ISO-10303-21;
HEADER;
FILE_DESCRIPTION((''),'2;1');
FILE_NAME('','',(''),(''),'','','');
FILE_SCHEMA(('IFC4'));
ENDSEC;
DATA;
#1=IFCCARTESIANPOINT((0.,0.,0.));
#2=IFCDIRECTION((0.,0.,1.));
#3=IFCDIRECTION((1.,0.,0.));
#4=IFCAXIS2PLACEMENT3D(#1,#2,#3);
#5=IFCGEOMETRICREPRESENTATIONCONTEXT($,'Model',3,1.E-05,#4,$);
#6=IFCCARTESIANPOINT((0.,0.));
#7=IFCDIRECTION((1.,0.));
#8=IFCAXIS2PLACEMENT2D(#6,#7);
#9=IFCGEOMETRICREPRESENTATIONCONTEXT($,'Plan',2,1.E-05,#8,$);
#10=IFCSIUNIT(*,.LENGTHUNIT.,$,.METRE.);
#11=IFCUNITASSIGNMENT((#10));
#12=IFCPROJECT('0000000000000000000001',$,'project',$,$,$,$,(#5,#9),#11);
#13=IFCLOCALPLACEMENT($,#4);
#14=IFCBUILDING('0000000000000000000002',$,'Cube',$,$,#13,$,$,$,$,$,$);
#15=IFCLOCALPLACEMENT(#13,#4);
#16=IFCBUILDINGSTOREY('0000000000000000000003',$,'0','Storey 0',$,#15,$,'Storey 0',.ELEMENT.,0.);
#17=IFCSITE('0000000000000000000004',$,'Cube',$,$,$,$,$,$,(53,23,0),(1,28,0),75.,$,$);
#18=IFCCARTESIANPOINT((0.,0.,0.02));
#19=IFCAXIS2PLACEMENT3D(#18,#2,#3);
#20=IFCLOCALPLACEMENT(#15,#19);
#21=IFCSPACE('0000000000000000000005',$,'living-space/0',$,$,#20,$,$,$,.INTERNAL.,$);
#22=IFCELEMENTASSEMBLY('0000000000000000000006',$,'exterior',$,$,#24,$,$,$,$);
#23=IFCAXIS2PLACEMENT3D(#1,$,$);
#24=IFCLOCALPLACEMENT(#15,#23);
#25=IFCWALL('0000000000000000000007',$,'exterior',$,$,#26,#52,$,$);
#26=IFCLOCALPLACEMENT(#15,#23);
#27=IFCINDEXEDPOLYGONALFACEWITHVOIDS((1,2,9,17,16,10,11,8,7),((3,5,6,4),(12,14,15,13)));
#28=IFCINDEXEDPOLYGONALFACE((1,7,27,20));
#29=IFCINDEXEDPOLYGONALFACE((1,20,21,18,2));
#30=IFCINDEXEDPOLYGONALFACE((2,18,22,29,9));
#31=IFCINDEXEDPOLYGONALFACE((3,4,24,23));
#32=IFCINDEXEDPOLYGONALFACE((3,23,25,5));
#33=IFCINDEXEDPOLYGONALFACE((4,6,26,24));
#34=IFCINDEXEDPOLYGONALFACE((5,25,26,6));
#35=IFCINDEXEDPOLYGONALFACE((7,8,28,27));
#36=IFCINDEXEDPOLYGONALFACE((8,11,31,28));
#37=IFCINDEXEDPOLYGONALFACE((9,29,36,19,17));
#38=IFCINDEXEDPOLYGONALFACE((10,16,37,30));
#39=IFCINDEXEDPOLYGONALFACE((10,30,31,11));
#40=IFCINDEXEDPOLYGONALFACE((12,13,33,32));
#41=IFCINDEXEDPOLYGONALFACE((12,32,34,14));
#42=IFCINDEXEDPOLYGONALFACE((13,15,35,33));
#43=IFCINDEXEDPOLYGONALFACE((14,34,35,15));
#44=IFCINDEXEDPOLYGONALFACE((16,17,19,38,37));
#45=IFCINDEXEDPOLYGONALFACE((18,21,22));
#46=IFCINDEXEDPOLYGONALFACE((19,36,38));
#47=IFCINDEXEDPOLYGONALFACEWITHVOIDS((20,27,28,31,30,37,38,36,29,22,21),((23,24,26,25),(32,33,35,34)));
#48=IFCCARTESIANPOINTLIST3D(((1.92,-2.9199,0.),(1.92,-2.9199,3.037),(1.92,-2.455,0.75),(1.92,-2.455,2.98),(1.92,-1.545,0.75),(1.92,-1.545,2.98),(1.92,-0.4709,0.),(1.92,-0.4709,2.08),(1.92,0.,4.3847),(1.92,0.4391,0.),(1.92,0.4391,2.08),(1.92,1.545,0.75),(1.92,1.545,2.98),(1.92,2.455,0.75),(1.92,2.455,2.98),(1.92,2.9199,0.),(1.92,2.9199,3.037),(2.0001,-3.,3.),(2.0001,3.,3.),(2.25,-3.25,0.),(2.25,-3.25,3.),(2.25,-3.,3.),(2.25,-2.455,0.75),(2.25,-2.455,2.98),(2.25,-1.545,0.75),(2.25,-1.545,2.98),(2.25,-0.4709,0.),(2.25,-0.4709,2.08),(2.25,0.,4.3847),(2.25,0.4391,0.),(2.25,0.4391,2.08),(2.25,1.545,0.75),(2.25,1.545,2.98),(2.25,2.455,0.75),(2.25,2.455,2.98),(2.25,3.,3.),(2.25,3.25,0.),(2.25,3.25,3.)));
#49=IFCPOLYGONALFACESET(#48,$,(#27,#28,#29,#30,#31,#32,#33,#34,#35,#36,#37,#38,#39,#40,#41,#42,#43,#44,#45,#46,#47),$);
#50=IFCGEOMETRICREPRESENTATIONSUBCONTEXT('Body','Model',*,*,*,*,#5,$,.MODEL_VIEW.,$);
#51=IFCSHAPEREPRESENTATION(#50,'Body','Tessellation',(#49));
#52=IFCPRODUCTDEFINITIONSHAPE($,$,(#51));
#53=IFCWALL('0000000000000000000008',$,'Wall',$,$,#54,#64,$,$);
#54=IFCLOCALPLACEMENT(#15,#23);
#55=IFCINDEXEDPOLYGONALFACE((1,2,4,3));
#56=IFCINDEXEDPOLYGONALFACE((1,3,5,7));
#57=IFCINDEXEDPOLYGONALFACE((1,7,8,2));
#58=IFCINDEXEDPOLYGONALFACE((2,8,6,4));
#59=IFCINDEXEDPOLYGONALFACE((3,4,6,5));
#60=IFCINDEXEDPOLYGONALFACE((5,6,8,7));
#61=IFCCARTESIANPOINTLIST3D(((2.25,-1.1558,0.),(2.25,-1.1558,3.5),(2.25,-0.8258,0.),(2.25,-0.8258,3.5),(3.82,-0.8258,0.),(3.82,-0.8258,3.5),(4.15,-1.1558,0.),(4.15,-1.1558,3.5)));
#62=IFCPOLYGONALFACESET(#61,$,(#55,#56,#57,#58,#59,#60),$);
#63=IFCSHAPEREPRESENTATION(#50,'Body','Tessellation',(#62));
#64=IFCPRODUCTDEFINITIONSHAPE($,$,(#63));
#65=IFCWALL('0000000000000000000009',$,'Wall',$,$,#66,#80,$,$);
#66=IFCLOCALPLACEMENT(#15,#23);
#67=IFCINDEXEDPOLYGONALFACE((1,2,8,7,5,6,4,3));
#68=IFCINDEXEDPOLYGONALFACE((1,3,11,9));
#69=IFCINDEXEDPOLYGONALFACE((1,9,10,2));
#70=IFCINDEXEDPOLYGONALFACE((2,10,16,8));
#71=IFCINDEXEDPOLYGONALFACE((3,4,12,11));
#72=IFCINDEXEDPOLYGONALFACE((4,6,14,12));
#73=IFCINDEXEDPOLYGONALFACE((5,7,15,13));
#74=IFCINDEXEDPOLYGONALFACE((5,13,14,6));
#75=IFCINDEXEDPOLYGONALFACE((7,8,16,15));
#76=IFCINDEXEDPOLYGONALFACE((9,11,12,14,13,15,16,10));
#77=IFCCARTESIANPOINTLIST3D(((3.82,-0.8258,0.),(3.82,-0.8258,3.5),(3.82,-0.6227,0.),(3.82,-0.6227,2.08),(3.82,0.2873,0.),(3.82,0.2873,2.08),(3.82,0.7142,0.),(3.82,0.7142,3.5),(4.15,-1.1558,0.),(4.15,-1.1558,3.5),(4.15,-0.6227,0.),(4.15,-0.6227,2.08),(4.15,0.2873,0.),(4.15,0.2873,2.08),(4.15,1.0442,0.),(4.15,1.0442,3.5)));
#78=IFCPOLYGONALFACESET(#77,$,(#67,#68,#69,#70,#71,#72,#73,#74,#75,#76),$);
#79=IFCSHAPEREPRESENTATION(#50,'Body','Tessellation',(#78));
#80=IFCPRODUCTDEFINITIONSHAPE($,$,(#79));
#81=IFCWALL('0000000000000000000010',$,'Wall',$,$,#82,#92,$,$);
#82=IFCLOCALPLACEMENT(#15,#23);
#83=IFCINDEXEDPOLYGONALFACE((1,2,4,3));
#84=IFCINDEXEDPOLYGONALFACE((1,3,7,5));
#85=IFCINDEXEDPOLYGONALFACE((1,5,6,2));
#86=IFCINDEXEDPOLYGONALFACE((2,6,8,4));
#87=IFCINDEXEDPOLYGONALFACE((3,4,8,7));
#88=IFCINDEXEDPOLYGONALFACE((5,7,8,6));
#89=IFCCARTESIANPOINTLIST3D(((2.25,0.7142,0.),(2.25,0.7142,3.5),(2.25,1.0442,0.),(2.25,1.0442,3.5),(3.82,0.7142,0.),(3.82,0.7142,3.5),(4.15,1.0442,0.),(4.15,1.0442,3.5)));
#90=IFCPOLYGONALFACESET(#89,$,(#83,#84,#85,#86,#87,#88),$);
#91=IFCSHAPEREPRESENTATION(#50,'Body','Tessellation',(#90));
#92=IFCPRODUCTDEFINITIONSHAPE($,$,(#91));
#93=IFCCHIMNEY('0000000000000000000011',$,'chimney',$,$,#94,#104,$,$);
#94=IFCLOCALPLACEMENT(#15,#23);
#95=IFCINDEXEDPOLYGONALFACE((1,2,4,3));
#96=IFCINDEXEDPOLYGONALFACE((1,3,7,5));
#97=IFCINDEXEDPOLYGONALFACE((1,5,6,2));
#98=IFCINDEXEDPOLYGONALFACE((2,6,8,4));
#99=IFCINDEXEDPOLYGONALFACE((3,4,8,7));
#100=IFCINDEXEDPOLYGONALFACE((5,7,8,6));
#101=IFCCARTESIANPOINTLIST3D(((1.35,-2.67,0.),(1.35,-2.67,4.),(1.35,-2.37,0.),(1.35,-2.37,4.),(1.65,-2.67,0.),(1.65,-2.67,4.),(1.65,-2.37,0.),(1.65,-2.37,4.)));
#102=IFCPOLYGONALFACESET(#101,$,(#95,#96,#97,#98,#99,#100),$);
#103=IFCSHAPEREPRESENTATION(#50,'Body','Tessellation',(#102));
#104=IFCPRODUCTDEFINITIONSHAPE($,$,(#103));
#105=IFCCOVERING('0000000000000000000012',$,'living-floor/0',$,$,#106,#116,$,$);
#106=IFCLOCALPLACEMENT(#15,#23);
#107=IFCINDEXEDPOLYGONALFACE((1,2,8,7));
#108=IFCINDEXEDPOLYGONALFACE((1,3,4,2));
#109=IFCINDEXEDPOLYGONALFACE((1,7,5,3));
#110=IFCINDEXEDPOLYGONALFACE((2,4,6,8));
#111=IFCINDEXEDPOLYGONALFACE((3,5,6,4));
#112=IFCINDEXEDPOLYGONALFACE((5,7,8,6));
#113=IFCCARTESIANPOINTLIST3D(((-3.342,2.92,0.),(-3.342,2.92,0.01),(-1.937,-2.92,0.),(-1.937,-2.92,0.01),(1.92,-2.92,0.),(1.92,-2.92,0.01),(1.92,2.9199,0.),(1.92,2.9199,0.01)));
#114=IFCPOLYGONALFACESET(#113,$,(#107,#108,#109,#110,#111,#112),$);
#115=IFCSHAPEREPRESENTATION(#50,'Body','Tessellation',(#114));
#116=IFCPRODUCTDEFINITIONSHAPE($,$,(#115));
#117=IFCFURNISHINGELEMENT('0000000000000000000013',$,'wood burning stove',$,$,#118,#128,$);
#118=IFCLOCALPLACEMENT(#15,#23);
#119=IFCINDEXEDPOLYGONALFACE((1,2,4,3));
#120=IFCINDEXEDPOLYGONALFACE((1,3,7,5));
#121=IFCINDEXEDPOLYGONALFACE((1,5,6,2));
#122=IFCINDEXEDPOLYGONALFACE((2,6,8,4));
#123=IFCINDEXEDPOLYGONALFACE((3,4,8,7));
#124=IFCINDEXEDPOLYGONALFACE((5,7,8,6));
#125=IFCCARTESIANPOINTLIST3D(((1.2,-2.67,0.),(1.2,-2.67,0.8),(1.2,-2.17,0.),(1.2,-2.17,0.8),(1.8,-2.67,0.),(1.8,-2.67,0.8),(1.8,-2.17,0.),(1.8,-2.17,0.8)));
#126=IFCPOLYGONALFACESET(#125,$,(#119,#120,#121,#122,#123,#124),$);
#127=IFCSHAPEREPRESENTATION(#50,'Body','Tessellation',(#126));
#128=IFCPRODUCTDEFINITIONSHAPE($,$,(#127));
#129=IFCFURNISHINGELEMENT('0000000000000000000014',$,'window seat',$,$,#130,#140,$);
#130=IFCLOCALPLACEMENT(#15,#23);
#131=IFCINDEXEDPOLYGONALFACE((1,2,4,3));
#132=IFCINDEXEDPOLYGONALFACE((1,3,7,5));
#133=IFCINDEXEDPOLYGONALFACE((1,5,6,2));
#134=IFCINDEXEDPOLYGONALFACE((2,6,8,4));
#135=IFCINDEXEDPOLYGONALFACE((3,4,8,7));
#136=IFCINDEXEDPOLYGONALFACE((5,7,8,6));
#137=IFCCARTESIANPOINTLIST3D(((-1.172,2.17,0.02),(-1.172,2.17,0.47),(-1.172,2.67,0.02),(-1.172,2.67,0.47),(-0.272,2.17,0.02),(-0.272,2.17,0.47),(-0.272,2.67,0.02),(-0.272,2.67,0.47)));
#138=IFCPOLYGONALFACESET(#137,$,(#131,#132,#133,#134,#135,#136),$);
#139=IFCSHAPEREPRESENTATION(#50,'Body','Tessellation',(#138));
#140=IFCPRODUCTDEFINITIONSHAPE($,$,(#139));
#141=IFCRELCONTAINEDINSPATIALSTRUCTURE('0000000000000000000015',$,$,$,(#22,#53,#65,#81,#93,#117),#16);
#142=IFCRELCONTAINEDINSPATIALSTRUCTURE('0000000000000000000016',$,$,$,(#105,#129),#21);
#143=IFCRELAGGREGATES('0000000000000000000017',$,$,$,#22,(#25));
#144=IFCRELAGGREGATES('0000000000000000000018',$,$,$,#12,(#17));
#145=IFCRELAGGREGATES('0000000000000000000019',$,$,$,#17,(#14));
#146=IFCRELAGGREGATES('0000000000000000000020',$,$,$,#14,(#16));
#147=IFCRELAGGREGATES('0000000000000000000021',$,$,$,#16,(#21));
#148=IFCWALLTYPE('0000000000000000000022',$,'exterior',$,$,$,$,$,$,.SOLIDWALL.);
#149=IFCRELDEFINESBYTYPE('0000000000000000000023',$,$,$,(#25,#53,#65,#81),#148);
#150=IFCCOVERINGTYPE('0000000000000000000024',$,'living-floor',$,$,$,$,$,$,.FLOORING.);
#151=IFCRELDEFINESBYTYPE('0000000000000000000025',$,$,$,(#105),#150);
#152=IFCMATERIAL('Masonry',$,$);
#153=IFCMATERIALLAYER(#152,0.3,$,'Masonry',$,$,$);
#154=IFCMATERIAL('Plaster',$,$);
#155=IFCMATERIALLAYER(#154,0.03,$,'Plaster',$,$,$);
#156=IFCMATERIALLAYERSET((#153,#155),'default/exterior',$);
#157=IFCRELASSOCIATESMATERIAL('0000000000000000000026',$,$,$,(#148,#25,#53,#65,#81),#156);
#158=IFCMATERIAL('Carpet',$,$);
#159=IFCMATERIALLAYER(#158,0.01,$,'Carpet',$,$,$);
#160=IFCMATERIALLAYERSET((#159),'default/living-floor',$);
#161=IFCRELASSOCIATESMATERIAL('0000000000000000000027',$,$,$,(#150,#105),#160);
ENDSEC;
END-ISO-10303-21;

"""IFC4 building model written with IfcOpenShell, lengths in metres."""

from ifc_helpers import new_model, si_unit, frame, origin, origin_with_axes, origin_2d_with_axis, place, context, subcontext, project, spatial, polyline, line, indexed_curve, outline, extrude, clip, bounded_halfspace, source, transform, mapped, material, layer, layer_set, layer_usage, type_object, element, aggregate, save


model = new_model("IFC4")

# Units and contexts
model_context = context("Model", 3, precision=1e-05, world=origin_with_axes())
plan_context = context("Plan", 2, precision=1e-05, world=origin_2d_with_axis())
body_context = subcontext(model_context, "Body", "Model", "MODEL_VIEW")
ifc_project = project(units=[si_unit("LENGTHUNIT", "METRE")], contexts=[model_context, plan_context])

# Site, building, storey
site = spatial("IfcSite", under=ifc_project, Name="Cube", RefLatitude=(53, 23, 0), RefLongitude=(1, 28, 0), RefElevation=75.0)
building_placement = place(None, origin_with_axes())
building = spatial("IfcBuilding", under=site, at=building_placement, Name="Cube")
storey_placement = place(building_placement, origin_with_axes())
storey = spatial("IfcBuildingStorey", under=building, at=storey_placement, Name="0", Description="Storey 0", LongName="Storey 0", CompositionType="ELEMENT", Elevation=0.0)

# Element assembly, wall, openings
ifc_material_1 = material(Name="Masonry")
ifc_layer_1 = layer(ifc_material_1, 0.3, Name="Masonry")
ifc_material_2 = material(Name="Plaster")
ifc_layer_2 = layer(ifc_material_2, 0.03, Name="Plaster")
ifc_layer_set_1 = layer_set([ifc_layer_1, ifc_layer_2], Name="default/exterior")
wall_type = type_object("IfcWallType", Name="exterior", PredefinedType="SOLIDWALL", material=ifc_layer_set_1)
assembly_1_placement = place(storey_placement, frame((2.0, -3.0, 0.0), z_axis=(0.0, 0.0, 1.0), x_axis=(0.0, 1.0, 0.0)))
assembly_1 = element("IfcElementAssembly", 1, at=assembly_1_placement, inside=storey, Name="exterior")
ifc_layer_usage_1 = layer_usage(ifc_layer_set_1, "AXIS2", "POSITIVE", -0.25)
wall_1_placement = place(assembly_1_placement, origin_with_axes())
wall_1 = element("IfcWall", 2, at=wall_1_placement, type_object=wall_type, material=ifc_layer_usage_1, Name="exterior", context=body_context, shape_type="Clipping", body=[
    clip(clip(clip(clip(extrude(outline(polyline([(0.0801, 0.08), (-0.25, -0.25), (6.25, -0.25), (5.9199, 0.08), (0.0801, 0.08)])), origin(), (0.0, 0.0, 1.0), 4.385), bounded_halfspace(frame((6.0, 0.0, 3.0), z_axis=(0.419069, 0.0, 0.907954), x_axis=(0.0, -1.0, 0.0)), False, origin(), polyline([(6.0, -1.0), (3.0, -1.0), (3.0, 1.0), (6.0, 1.0), (6.0, -1.0)]))), bounded_halfspace(frame((6.0, 0.0, 3.0), z_axis=(0.0, 0.0, 1.0), x_axis=(0.0, 1.0, 0.0)), False, origin(), polyline([(6.0, 1.0), (7.0, 1.0), (7.0, -1.0), (6.0, -1.0), (6.0, 1.0)]))), bounded_halfspace(frame((3.0, 0.0, 4.3847), z_axis=(-0.419069, 0.0, 0.907954), x_axis=(0.0, -1.0, 0.0)), False, origin(), polyline([(3.0, -1.0), (0.0, -1.0), (0.0, 1.0), (3.0, 1.0), (3.0, -1.0)]))), bounded_halfspace(frame((0.0, 0.0, 3.0), z_axis=(0.0, 0.0, 1.0), x_axis=(0.0, -1.0, 0.0)), False, origin(), polyline([(0.0, -1.0), (-1.0, -1.0), (-1.0, 1.0), (0.0, 1.0), (0.0, -1.0)]))),
])
opening_1_placement = place(wall_1_placement, frame((0.545, -0.25, 0.75), z_axis=(0.0, 0.0, 1.0), x_axis=(1.0, 0.0, 0.0)))
element("IfcOpeningElement", 3, at=opening_1_placement, cuts=wall_1, PredefinedType="OPENING", context=body_context, shape_type="SweptSolid", body=[
    extrude(outline(polyline([(0.0, -0.02), (0.91, -0.02), (0.91, 0.35), (0.0, 0.35), (0.0, -0.02)])), origin(), (0.0, 0.0, 1.0), 2.23),
])
opening_2_placement = place(wall_1_placement, frame((4.545, -0.25, 0.75), z_axis=(0.0, 0.0, 1.0), x_axis=(1.0, 0.0, 0.0)))
element("IfcOpeningElement", 4, at=opening_2_placement, cuts=wall_1, PredefinedType="OPENING", context=body_context, shape_type="SweptSolid", body=[
    extrude(outline(polyline([(0.0, -0.02), (0.91, -0.02), (0.91, 0.35), (0.0, 0.35), (0.0, -0.02)])), origin(), (0.0, 0.0, 1.0), 2.23),
])
shared_shape_1 = source(origin_with_axes(), body_context, "Body", "SweptSolid", [
    extrude(outline(indexed_curve([(0.0, 0.0), (0.91, 0.0), (0.91, 2.08), (0.0, 2.08)], segments=[line(1, 2, 3, 4, 1)])), frame((0.0, -0.6, 0.0), z_axis=(0.0, -1.0, 0.0), x_axis=(1.0, 0.0, 0.0)), (0.0, 0.0, -1.0), 1.2),
])
opening_3_placement = place(wall_1_placement, frame((2.5291, -0.25, 0.0), z_axis=(0.0, 0.0, 1.0), x_axis=(1.0, 0.0, 0.0)))
element("IfcOpeningElement", 5, at=opening_3_placement, cuts=wall_1, PredefinedType="OPENING", context=body_context, shape_type="MappedRepresentation", body=[
    mapped(shared_shape_1, transform((0.0, 0.0, 0.0), x_axis=(1.0, 0.0, 0.0), y_axis=(0.0, 1.0, 0.0), z_axis=(0.0, 0.0, 1.0), scale=1.0)),
])
aggregate(assembly_1, [wall_1])

# Wall
ifc_layer_usage_2 = layer_usage(ifc_layer_set_1, "AXIS2", "POSITIVE", 0.0)
wall_2_placement = place(storey_placement, frame((2.25, -1.1558, 0.0), z_axis=(0.0, 0.0, 1.0), x_axis=(1.0, 0.0, 0.0)))
element("IfcWall", 6, at=wall_2_placement, inside=storey, type_object=wall_type, material=ifc_layer_usage_2, Name="Wall", context=body_context, shape_type="SweptSolid", body=[
    extrude(outline(indexed_curve([(0.0, 0.0), (0.0, 0.33), (1.57, 0.33), (1.9, 0.0)], segments=[line(1, 2, 3, 4, 1)])), origin_with_axes(), (0.0, 0.0, 1.0), 3.5),
])

# Wall, opening
ifc_layer_usage_3 = layer_usage(ifc_layer_set_1, "AXIS2", "POSITIVE", 0.0)
wall_3_placement = place(storey_placement, frame((4.15, -1.1558, 0.0), z_axis=(0.0, 0.0, 1.0), x_axis=(0.0, 1.0, 0.0)))
wall_3 = element("IfcWall", 7, at=wall_3_placement, inside=storey, type_object=wall_type, material=ifc_layer_usage_3, Name="Wall", context=body_context, shape_type="SweptSolid", body=[
    extrude(outline(indexed_curve([(0.0, 0.0), (0.33, 0.33), (1.87, 0.33), (2.2, 0.0)], segments=[line(1, 2, 3, 4, 1)])), origin_with_axes(), (0.0, 0.0, 1.0), 3.5),
])
shared_shape_2 = source(origin_with_axes(), body_context, "Body", "SweptSolid", [
    extrude(outline(indexed_curve([(0.0, 0.0), (0.91, 0.0), (0.91, 2.08), (0.0, 2.08)], segments=[line(1, 2, 3, 4, 1)])), frame((0.0, -0.6, 0.0), z_axis=(0.0, -1.0, 0.0), x_axis=(1.0, 0.0, 0.0)), (0.0, 0.0, -1.0), 1.2),
])
opening_4_placement = place(wall_3_placement, frame((0.5331, 0.0, 0.0), z_axis=(0.0, 0.0, 1.0), x_axis=(1.0, 0.0, 0.0)))
element("IfcOpeningElement", 8, at=opening_4_placement, cuts=wall_3, PredefinedType="OPENING", context=body_context, shape_type="MappedRepresentation", body=[
    mapped(shared_shape_2, transform((0.0, 0.0, 0.0), x_axis=(1.0, 0.0, 0.0), y_axis=(0.0, 1.0, 0.0), z_axis=(0.0, 0.0, 1.0), scale=1.0)),
])

# Wall
ifc_layer_usage_4 = layer_usage(ifc_layer_set_1, "AXIS2", "POSITIVE", 0.0)
wall_4_placement = place(storey_placement, frame((4.15, 1.0442, 0.0), z_axis=(0.0, 0.0, 1.0), x_axis=(-1.0, 0.0, 0.0)))
element("IfcWall", 9, at=wall_4_placement, inside=storey, type_object=wall_type, material=ifc_layer_usage_4, Name="Wall", context=body_context, shape_type="SweptSolid", body=[
    extrude(outline(indexed_curve([(0.0, 0.0), (0.33, 0.33), (1.9, 0.33), (1.9, 0.0)], segments=[line(1, 2, 3, 4, 1)])), origin_with_axes(), (0.0, 0.0, 1.0), 3.5),
])

# Chimney
chimney_placement = place(storey_placement, frame((1.35, -2.67, 0.0), z_axis=(0.0, 0.0, 1.0), x_axis=(1.0, 0.0, 0.0)))
element("IfcChimney", 10, at=chimney_placement, inside=storey, Name="chimney", context=body_context, shape_type="SweptSolid", body=[
    extrude(outline(indexed_curve([(0.0, 0.0), (0.3, 0.0), (0.3, 0.3), (0.0, 0.3)])), None, (0.0, 0.0, 1.0), 4.0),
])

# Shared definitions
space_placement = place(storey_placement, frame((0.0, 0.0, 0.02), z_axis=(0.0, 0.0, 1.0), x_axis=(1.0, 0.0, 0.0)))
space = spatial("IfcSpace", under=storey, at=space_placement, Name="living-space/0", PredefinedType="INTERNAL")

# Covering
ifc_material_3 = material(Name="Carpet")
ifc_layer_3 = layer(ifc_material_3, 0.01, Name="Carpet")
ifc_layer_set_2 = layer_set([ifc_layer_3], Name="default/living-floor")
ifc_layer_usage_5 = layer_usage(ifc_layer_set_2, "AXIS3", "POSITIVE", 0.0)
covering_type = type_object("IfcCoveringType", Name="living-floor", PredefinedType="FLOORING", material=ifc_layer_set_2)
covering_placement = place(space_placement, frame((0.0, 0.0, -0.02), z_axis=(0.0, 0.0, 1.0), x_axis=(1.0, 0.0, 0.0)))
element("IfcCovering", 11, at=covering_placement, inside=space, type_object=covering_type, material=ifc_layer_usage_5, Name="living-floor/0", context=body_context, shape_type="SweptSolid", body=[
    extrude(outline(polyline([(1.92, 2.9199), (-3.342, 2.92), (-1.937, -2.92), (1.92, -2.92), (1.92, 2.9199)])), origin_with_axes(), (0.0, 0.0, 1.0), 0.01),
])

# Furnishing elements
furnishing_1_placement = place(storey_placement, frame((1.2, -2.67, 0.0), z_axis=(0.0, 0.0, 1.0), x_axis=(1.0, 0.0, 0.0)))
element("IfcFurnishingElement", 12, at=furnishing_1_placement, inside=storey, Name="wood burning stove", context=body_context, shape_type="SweptSolid", body=[
    extrude(outline(indexed_curve([(0.0, 0.0), (0.6, 0.0), (0.6, 0.5), (0.0, 0.5)])), None, (0.0, 0.0, 1.0), 0.8),
])
furnishing_2_placement = place(space_placement, frame((-1.172, 2.17, 0.0), z_axis=(0.0, 0.0, 1.0), x_axis=(1.0, 0.0, 0.0)))
element("IfcFurnishingElement", 13, at=furnishing_2_placement, inside=space, Name="window seat", context=body_context, shape_type="SweptSolid", body=[
    extrude(outline(indexed_curve([(0.0, 0.0), (0.9, 0.0), (0.9, 0.5), (0.0, 0.5)])), None, (0.0, 0.0, 1.0), 0.45),
])

save(model, "model.ifc")
